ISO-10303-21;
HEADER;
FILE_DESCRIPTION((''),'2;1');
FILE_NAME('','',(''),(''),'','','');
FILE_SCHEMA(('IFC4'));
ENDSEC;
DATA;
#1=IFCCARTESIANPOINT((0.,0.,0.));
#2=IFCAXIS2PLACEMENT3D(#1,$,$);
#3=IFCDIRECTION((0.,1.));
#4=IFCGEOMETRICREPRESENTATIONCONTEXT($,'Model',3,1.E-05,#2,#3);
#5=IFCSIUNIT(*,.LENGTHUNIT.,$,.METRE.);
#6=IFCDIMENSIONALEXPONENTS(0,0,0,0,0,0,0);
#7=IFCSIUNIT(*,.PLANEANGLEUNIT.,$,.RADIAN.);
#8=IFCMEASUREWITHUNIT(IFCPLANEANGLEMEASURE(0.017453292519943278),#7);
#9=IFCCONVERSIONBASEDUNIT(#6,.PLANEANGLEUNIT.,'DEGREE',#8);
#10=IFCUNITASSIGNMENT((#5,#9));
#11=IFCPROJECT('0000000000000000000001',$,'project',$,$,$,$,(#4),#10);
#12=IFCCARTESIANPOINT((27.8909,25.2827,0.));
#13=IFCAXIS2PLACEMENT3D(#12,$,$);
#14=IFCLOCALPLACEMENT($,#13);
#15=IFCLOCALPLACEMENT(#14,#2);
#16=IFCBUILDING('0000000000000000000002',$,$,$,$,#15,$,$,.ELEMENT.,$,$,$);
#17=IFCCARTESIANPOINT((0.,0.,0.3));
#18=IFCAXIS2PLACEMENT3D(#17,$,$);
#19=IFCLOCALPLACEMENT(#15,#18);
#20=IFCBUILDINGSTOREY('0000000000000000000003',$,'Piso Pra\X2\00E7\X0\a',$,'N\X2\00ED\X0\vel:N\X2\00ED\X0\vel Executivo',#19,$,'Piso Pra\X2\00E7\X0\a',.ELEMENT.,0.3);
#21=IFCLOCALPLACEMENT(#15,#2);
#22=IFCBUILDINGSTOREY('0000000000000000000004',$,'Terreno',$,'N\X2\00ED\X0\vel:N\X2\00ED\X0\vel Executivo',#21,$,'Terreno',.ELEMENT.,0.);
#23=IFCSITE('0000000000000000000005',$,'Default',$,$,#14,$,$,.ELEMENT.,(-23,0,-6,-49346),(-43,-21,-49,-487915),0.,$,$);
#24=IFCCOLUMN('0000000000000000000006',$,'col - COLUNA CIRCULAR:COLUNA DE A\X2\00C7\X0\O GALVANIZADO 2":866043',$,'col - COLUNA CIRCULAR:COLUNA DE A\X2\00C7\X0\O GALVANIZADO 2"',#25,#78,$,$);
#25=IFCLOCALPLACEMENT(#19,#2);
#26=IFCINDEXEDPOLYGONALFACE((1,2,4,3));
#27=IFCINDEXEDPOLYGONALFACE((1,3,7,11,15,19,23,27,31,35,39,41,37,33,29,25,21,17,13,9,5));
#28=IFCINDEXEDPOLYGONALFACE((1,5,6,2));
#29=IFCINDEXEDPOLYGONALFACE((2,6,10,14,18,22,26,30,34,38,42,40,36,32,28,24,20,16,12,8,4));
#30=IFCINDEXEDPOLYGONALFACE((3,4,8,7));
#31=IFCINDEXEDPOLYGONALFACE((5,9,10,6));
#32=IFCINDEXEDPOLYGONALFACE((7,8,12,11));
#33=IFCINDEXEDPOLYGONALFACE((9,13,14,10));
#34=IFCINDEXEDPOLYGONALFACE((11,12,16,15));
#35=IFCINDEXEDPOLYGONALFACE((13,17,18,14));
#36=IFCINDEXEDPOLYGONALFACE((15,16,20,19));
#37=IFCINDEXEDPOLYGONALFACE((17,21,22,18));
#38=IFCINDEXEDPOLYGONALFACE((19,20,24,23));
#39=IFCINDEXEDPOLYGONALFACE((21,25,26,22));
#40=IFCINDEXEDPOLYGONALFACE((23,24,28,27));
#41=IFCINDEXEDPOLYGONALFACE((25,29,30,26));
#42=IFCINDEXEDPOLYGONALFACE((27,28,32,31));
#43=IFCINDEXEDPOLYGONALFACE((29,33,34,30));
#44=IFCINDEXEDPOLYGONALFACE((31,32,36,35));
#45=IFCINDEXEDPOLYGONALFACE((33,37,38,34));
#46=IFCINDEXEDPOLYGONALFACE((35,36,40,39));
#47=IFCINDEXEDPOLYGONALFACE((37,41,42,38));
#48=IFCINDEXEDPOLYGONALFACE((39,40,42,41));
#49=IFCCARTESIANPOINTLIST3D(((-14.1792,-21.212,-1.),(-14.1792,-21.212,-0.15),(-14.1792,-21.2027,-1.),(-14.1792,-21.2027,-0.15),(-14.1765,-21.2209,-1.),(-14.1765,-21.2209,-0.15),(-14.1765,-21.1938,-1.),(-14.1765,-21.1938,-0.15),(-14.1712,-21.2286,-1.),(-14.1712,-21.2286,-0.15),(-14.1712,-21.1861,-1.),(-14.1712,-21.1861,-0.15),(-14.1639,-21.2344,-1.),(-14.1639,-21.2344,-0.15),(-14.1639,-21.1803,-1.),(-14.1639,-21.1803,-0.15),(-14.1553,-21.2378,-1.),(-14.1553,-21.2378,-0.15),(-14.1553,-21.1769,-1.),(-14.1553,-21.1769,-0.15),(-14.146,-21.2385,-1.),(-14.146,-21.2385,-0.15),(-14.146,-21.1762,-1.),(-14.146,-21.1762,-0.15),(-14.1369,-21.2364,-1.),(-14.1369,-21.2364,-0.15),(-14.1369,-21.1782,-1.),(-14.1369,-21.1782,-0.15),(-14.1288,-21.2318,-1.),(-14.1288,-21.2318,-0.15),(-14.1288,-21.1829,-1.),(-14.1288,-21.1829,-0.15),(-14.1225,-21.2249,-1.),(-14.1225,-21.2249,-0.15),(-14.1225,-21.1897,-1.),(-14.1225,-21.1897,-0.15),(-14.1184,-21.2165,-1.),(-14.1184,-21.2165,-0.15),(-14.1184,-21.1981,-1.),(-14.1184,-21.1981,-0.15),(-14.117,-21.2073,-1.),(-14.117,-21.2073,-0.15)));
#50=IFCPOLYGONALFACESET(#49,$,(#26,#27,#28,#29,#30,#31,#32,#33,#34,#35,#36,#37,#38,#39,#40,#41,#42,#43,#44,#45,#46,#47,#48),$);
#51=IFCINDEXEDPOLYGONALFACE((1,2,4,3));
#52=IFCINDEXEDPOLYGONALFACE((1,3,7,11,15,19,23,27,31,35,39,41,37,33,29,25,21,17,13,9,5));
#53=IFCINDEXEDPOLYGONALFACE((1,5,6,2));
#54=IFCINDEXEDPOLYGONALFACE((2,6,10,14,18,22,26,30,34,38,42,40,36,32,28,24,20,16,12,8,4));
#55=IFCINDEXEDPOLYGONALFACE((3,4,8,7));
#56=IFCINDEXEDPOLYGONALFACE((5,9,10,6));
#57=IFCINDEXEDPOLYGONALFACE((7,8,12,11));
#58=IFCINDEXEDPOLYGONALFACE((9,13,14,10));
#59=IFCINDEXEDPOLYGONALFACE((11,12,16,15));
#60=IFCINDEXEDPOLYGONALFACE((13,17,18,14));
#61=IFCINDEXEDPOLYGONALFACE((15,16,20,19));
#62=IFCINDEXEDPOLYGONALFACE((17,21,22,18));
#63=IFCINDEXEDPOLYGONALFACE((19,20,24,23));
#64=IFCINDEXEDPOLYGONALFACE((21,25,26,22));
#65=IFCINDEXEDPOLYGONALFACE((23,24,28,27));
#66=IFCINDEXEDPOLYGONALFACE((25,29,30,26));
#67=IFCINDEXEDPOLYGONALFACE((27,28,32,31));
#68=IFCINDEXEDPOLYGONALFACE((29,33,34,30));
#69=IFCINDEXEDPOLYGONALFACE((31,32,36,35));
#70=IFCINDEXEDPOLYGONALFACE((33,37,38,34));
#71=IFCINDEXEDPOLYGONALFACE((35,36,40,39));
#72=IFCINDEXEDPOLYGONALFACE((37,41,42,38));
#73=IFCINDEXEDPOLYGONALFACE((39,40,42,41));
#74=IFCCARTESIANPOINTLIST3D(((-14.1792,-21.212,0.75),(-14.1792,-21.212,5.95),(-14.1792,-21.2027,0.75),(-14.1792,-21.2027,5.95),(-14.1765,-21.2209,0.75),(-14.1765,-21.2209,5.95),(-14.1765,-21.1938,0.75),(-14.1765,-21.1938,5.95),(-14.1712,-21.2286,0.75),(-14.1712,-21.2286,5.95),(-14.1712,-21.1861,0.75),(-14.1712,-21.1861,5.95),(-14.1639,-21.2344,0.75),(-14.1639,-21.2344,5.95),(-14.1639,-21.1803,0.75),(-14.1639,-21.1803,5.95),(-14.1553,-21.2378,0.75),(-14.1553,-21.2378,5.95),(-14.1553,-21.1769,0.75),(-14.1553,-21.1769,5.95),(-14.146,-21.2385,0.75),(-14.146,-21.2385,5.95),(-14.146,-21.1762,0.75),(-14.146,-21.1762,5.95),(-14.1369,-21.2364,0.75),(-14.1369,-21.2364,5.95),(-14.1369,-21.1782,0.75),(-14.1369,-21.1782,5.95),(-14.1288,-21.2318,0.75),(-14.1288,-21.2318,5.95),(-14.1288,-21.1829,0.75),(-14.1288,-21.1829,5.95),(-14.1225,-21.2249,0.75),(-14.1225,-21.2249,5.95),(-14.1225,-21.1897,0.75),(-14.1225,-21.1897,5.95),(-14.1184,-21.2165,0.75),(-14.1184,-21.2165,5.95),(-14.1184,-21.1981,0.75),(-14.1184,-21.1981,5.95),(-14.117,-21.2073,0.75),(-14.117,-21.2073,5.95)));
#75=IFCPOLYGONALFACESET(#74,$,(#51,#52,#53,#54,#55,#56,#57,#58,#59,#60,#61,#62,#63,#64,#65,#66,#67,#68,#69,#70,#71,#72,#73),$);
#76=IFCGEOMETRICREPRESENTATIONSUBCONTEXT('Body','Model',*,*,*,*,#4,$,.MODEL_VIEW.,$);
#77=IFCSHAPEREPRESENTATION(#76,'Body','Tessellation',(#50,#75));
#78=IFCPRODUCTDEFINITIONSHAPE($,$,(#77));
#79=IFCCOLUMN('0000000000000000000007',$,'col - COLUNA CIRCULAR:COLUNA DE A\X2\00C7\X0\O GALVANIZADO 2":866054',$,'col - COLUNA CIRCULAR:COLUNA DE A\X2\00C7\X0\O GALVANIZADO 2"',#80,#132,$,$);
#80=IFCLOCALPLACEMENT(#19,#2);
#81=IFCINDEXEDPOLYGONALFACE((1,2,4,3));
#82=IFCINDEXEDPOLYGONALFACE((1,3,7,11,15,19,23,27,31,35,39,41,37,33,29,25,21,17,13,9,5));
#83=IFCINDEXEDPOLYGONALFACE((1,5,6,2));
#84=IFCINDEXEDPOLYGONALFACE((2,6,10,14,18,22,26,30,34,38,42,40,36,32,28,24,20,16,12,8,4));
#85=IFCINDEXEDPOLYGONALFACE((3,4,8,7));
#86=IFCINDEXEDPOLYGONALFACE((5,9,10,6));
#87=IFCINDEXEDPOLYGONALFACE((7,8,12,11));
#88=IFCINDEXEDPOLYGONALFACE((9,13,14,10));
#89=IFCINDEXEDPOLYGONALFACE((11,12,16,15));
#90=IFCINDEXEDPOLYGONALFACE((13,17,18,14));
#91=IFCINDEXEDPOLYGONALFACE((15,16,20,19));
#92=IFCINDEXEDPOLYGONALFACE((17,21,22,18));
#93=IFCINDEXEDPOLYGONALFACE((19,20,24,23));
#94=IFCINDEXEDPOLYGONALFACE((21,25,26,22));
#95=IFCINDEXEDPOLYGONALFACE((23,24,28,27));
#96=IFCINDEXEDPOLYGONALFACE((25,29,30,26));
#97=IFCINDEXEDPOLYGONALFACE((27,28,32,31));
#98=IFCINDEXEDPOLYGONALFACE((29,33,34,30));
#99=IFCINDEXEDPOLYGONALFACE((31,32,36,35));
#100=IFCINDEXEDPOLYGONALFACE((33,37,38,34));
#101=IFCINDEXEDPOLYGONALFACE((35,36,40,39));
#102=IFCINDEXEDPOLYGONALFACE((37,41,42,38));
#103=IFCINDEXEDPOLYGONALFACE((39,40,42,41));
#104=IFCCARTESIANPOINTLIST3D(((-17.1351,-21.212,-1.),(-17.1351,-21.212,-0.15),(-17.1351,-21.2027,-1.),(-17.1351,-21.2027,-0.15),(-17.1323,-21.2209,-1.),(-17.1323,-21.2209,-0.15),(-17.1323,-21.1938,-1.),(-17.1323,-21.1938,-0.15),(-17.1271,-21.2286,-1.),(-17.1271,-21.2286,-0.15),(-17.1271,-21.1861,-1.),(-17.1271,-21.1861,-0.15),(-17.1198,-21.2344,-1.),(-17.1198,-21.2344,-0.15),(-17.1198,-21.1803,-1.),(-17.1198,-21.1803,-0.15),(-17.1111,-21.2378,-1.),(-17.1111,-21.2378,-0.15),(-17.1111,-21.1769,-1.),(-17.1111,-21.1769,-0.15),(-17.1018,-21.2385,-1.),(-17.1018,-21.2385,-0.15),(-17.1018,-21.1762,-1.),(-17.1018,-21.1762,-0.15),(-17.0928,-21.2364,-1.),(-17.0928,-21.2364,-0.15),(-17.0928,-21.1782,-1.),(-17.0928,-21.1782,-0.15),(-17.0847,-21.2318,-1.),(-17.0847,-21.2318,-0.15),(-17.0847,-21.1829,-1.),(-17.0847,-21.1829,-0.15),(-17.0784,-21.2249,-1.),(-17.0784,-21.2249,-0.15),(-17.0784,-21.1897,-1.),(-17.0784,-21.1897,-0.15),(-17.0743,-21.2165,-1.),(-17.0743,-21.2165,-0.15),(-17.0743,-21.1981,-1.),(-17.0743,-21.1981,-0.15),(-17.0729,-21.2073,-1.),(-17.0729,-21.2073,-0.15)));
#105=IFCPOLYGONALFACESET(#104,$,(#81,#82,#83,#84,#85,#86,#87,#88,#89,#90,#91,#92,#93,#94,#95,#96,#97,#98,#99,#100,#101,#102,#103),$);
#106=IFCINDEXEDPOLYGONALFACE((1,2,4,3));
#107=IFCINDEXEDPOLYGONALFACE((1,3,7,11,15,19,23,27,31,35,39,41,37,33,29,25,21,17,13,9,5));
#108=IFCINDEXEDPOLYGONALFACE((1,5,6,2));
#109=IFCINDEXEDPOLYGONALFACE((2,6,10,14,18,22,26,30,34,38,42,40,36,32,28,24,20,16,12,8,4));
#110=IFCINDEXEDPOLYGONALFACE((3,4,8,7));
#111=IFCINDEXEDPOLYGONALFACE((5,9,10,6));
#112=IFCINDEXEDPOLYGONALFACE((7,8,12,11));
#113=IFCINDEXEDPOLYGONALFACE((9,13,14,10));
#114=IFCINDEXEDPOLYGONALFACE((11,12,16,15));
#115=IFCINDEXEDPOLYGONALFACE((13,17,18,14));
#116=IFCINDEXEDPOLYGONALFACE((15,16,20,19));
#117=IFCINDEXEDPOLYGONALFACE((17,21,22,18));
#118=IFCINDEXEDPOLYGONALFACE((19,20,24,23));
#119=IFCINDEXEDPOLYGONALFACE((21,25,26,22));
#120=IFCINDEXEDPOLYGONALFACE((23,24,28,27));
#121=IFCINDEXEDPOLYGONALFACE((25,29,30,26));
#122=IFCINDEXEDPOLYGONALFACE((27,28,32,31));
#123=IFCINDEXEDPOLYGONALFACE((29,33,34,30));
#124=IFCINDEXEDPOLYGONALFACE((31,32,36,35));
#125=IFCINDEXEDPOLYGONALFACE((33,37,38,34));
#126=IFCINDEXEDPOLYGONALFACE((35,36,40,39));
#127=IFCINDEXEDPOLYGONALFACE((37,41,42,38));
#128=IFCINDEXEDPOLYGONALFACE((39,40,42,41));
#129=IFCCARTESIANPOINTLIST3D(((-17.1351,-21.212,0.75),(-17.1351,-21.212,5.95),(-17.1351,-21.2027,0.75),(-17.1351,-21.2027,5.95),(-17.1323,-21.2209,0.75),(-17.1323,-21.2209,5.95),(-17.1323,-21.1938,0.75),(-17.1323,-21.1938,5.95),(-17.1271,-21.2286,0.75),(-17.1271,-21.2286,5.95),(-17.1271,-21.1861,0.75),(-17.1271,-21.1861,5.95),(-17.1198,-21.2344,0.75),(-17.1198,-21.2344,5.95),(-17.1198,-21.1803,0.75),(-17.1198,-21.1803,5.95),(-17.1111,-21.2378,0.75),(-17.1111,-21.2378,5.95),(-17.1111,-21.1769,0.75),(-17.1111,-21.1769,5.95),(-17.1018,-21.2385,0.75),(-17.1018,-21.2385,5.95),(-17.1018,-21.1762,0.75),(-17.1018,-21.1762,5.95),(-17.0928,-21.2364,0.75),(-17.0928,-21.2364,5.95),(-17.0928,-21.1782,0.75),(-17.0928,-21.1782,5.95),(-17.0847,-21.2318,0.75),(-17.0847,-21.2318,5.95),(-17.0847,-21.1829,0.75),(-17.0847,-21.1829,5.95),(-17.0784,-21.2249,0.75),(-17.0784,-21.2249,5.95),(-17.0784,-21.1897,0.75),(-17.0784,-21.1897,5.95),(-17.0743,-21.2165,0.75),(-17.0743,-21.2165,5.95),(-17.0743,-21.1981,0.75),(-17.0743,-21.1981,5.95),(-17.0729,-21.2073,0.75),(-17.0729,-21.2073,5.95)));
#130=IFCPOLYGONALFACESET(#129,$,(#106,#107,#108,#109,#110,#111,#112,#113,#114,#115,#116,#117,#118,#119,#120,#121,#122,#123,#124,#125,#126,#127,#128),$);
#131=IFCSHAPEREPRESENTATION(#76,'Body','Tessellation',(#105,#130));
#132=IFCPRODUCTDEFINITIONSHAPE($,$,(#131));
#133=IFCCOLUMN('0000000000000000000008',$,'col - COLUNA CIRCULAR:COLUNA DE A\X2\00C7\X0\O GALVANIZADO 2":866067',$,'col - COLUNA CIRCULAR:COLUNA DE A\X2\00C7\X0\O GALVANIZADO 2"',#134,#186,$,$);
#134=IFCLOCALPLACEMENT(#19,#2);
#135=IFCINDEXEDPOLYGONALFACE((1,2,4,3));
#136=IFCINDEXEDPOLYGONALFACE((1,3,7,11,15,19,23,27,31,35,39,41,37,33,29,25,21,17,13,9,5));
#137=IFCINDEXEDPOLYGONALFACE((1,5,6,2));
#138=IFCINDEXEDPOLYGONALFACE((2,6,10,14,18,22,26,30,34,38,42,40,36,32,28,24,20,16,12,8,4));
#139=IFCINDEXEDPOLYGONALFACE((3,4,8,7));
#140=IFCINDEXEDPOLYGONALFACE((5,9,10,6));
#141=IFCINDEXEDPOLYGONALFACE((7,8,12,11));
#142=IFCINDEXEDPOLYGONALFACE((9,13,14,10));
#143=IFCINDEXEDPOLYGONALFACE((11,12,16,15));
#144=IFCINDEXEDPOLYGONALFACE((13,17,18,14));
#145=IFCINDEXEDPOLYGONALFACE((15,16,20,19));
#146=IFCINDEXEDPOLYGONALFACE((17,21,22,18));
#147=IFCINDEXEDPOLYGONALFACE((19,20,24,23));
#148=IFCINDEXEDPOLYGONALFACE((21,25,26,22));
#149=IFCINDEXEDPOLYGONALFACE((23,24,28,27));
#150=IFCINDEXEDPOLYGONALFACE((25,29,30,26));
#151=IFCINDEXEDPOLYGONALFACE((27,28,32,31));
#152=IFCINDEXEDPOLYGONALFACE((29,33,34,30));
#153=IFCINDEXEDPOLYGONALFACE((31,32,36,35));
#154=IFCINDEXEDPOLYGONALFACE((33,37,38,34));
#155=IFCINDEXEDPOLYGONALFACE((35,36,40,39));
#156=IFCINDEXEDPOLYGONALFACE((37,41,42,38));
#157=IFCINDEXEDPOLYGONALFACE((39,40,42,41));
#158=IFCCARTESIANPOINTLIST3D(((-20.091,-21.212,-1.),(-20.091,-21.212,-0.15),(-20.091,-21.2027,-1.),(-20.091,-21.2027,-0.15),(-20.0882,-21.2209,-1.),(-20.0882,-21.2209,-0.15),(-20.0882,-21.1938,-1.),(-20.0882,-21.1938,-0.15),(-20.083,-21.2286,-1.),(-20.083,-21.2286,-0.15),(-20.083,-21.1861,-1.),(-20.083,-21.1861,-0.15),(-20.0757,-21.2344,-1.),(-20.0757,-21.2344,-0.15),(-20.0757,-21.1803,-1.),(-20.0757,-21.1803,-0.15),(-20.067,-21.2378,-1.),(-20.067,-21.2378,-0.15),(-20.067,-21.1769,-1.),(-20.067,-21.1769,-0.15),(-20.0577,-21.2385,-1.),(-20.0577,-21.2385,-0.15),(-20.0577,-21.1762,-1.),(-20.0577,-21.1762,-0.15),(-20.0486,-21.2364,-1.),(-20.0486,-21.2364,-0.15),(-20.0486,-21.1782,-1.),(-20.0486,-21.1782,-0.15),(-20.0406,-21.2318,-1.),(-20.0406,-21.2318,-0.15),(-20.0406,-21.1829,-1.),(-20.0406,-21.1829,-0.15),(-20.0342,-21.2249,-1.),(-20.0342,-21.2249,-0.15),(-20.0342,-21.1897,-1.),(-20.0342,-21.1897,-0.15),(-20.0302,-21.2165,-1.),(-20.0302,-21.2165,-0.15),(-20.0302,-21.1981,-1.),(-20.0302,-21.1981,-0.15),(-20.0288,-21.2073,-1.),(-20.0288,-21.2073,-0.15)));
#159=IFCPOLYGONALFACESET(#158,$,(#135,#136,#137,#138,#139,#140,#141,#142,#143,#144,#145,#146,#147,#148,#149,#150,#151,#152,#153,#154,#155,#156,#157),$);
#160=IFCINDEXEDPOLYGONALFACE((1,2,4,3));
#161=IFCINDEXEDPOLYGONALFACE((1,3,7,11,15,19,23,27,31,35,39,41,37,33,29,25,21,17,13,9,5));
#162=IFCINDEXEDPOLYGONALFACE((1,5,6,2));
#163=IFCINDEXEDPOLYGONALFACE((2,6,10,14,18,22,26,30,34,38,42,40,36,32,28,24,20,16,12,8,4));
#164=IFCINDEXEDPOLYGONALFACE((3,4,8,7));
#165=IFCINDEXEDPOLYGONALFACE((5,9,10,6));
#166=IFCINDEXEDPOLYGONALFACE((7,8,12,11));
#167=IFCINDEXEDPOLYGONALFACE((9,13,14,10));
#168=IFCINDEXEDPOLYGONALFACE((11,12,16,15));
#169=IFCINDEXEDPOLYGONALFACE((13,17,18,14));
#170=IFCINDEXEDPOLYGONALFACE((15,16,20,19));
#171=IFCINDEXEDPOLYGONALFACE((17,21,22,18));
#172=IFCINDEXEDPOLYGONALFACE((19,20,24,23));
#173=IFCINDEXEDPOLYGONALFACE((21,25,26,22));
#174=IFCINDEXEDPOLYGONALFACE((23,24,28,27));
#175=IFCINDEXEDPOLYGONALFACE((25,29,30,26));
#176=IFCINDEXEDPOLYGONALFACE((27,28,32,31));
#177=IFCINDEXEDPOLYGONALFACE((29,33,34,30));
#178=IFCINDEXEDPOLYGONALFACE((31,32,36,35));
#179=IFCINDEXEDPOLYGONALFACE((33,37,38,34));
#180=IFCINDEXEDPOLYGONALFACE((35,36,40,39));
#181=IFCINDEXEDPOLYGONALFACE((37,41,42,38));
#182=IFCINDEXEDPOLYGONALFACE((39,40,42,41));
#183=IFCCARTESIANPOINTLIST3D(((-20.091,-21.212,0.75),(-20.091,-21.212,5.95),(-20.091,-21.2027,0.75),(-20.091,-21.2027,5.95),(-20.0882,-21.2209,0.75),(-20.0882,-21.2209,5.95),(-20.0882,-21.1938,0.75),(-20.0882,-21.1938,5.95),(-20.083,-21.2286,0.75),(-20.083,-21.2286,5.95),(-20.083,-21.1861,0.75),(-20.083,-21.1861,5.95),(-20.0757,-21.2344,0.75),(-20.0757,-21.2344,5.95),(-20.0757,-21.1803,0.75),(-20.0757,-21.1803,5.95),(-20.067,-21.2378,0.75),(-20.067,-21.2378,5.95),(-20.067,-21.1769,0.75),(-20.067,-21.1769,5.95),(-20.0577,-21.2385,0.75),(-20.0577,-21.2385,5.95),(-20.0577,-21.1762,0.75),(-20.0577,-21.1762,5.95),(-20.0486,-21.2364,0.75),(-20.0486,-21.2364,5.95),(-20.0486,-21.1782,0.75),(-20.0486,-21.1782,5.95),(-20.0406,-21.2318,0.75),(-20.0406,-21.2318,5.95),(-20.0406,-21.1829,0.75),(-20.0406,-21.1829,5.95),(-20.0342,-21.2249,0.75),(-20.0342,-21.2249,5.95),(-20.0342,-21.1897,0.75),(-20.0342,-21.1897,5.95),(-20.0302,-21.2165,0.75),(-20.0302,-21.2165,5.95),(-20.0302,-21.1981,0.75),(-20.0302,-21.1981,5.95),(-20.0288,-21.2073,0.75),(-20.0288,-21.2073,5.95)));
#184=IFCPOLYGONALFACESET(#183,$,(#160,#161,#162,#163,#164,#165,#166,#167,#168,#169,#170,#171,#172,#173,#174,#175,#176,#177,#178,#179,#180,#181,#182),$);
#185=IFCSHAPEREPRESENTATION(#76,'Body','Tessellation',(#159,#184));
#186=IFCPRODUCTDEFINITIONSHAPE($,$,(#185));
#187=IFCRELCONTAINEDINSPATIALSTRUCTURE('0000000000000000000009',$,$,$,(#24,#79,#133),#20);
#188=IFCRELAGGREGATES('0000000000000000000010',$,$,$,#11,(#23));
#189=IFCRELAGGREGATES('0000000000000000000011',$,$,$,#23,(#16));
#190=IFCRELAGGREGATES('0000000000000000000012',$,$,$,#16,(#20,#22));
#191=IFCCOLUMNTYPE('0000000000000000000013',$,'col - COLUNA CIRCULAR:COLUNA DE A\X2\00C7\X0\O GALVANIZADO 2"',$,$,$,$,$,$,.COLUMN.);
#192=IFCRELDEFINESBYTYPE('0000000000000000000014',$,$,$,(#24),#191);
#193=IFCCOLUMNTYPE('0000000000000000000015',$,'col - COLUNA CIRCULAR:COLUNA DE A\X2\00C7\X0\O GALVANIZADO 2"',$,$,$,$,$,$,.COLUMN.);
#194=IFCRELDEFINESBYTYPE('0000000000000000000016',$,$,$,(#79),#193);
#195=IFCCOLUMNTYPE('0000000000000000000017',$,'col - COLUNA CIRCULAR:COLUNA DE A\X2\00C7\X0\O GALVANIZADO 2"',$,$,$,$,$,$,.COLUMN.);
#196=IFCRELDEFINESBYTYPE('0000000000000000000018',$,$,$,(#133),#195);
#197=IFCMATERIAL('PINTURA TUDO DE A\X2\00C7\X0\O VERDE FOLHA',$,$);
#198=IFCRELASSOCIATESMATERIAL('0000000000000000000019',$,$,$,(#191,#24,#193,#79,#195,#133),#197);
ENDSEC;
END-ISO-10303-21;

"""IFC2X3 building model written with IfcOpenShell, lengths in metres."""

from ifc_helpers import new_model, entity, si_unit, converted_unit, direction, frame, origin, origin_2d_with_axis, place, context, subcontext, project, spatial, circle, extrude, source, transform, mapped, material, type_object, type_shapes, element, save


model = new_model("IFC2X3")

# Units and contexts
model_context = context("Model", 3, precision=1e-05, world=origin(), true_north=direction((0.0, 1.0)))
body_context = subcontext(model_context, "Body", "Model", "MODEL_VIEW")
ifc_project = project(units=[si_unit("LENGTHUNIT", "METRE"), converted_unit("PLANEANGLEUNIT", "DEGREE", entity("IfcPlaneAngleMeasure", 0.017453292519943278), si_unit("PLANEANGLEUNIT", "RADIAN"), dimensions=[0, 0, 0, 0, 0, 0, 0])], contexts=[model_context])

# Site, building, storey
site_placement = place(None, frame((27.8909, 25.2827, 0.0)))
site = spatial("IfcSite", under=ifc_project, at=site_placement, Name="Default", CompositionType="ELEMENT", RefLatitude=(-23, 0, -6, -49346), RefLongitude=(-43, -21, -49, -487915), RefElevation=0.0)
building_placement = place(site_placement, origin())
building = spatial("IfcBuilding", under=site, at=building_placement, CompositionType="ELEMENT")
storey_1_placement = place(building_placement, frame((0.0, 0.0, 0.3)))
storey_1 = spatial("IfcBuildingStorey", under=building, at=storey_1_placement, Name="Piso Praça", ObjectType="Nível:Nível Executivo", LongName="Piso Praça", CompositionType="ELEMENT", Elevation=0.3)

# Columns
ifc_material_1 = material(Name="PINTURA TUDO DE AÇO VERDE FOLHA")
column_type_1 = type_object("IfcColumnType", Name="col - COLUNA CIRCULAR:COLUNA DE AÇO GALVANIZADO 2\"", PredefinedType="COLUMN", material=ifc_material_1)
shared_shape_1 = source(origin(), body_context, "Body", "SweptSolid", [
    extrude(circle(Radius=0.0312, at=origin_2d_with_axis()), frame((-14.1483, -21.2073, -0.7)), (0.0, 0.0, 1.0), 0.85),
    extrude(circle(Radius=0.0312, at=origin_2d_with_axis()), frame((-14.1483, -21.2073, 1.05)), (0.0, 0.0, 1.0), 5.2),
])
type_shapes(column_type_1, [shared_shape_1])
column_1_placement = place(storey_1_placement, frame((0.0, 0.0, -0.3)))
element("IfcColumn", 1, at=column_1_placement, inside=storey_1, type_object=column_type_1, material=ifc_material_1, Name="col - COLUNA CIRCULAR:COLUNA DE AÇO GALVANIZADO 2\":866043", ObjectType="col - COLUNA CIRCULAR:COLUNA DE AÇO GALVANIZADO 2\"", context=body_context, shape_type="MappedRepresentation", body=[
    mapped(shared_shape_1, transform((0.0, 0.0, 0.0), scale=1.0)),
])
column_type_2 = type_object("IfcColumnType", Name="col - COLUNA CIRCULAR:COLUNA DE AÇO GALVANIZADO 2\"", PredefinedType="COLUMN", material=ifc_material_1)
shared_shape_2 = source(origin(), body_context, "Body", "SweptSolid", [
    extrude(circle(Radius=0.0312, at=origin_2d_with_axis()), frame((-17.1042, -21.2073, -0.7)), (0.0, 0.0, 1.0), 0.85),
    extrude(circle(Radius=0.0312, at=origin_2d_with_axis()), frame((-17.1042, -21.2073, 1.05)), (0.0, 0.0, 1.0), 5.2),
])
type_shapes(column_type_2, [shared_shape_2])
column_2_placement = place(storey_1_placement, frame((0.0, 0.0, -0.3)))
element("IfcColumn", 2, at=column_2_placement, inside=storey_1, type_object=column_type_2, material=ifc_material_1, Name="col - COLUNA CIRCULAR:COLUNA DE AÇO GALVANIZADO 2\":866054", ObjectType="col - COLUNA CIRCULAR:COLUNA DE AÇO GALVANIZADO 2\"", context=body_context, shape_type="MappedRepresentation", body=[
    mapped(shared_shape_2, transform((0.0, 0.0, 0.0), scale=1.0)),
])
column_type_3 = type_object("IfcColumnType", Name="col - COLUNA CIRCULAR:COLUNA DE AÇO GALVANIZADO 2\"", PredefinedType="COLUMN", material=ifc_material_1)
shared_shape_3 = source(origin(), body_context, "Body", "SweptSolid", [
    extrude(circle(Radius=0.0312, at=origin_2d_with_axis()), frame((-20.0601, -21.2073, -0.7)), (0.0, 0.0, 1.0), 0.85),
    extrude(circle(Radius=0.0312, at=origin_2d_with_axis()), frame((-20.0601, -21.2073, 1.05)), (0.0, 0.0, 1.0), 5.2),
])
type_shapes(column_type_3, [shared_shape_3])
column_3_placement = place(storey_1_placement, frame((0.0, 0.0, -0.3)))
element("IfcColumn", 3, at=column_3_placement, inside=storey_1, type_object=column_type_3, material=ifc_material_1, Name="col - COLUNA CIRCULAR:COLUNA DE AÇO GALVANIZADO 2\":866067", ObjectType="col - COLUNA CIRCULAR:COLUNA DE AÇO GALVANIZADO 2\"", context=body_context, shape_type="MappedRepresentation", body=[
    mapped(shared_shape_3, transform((0.0, 0.0, 0.0), scale=1.0)),
])

# Shared definitions
storey_2_placement = place(building_placement, origin())
storey_2 = spatial("IfcBuildingStorey", under=building, at=storey_2_placement, Name="Terreno", ObjectType="Nível:Nível Executivo", LongName="Terreno", CompositionType="ELEMENT", Elevation=0.0)

save(model, "model.ifc")
